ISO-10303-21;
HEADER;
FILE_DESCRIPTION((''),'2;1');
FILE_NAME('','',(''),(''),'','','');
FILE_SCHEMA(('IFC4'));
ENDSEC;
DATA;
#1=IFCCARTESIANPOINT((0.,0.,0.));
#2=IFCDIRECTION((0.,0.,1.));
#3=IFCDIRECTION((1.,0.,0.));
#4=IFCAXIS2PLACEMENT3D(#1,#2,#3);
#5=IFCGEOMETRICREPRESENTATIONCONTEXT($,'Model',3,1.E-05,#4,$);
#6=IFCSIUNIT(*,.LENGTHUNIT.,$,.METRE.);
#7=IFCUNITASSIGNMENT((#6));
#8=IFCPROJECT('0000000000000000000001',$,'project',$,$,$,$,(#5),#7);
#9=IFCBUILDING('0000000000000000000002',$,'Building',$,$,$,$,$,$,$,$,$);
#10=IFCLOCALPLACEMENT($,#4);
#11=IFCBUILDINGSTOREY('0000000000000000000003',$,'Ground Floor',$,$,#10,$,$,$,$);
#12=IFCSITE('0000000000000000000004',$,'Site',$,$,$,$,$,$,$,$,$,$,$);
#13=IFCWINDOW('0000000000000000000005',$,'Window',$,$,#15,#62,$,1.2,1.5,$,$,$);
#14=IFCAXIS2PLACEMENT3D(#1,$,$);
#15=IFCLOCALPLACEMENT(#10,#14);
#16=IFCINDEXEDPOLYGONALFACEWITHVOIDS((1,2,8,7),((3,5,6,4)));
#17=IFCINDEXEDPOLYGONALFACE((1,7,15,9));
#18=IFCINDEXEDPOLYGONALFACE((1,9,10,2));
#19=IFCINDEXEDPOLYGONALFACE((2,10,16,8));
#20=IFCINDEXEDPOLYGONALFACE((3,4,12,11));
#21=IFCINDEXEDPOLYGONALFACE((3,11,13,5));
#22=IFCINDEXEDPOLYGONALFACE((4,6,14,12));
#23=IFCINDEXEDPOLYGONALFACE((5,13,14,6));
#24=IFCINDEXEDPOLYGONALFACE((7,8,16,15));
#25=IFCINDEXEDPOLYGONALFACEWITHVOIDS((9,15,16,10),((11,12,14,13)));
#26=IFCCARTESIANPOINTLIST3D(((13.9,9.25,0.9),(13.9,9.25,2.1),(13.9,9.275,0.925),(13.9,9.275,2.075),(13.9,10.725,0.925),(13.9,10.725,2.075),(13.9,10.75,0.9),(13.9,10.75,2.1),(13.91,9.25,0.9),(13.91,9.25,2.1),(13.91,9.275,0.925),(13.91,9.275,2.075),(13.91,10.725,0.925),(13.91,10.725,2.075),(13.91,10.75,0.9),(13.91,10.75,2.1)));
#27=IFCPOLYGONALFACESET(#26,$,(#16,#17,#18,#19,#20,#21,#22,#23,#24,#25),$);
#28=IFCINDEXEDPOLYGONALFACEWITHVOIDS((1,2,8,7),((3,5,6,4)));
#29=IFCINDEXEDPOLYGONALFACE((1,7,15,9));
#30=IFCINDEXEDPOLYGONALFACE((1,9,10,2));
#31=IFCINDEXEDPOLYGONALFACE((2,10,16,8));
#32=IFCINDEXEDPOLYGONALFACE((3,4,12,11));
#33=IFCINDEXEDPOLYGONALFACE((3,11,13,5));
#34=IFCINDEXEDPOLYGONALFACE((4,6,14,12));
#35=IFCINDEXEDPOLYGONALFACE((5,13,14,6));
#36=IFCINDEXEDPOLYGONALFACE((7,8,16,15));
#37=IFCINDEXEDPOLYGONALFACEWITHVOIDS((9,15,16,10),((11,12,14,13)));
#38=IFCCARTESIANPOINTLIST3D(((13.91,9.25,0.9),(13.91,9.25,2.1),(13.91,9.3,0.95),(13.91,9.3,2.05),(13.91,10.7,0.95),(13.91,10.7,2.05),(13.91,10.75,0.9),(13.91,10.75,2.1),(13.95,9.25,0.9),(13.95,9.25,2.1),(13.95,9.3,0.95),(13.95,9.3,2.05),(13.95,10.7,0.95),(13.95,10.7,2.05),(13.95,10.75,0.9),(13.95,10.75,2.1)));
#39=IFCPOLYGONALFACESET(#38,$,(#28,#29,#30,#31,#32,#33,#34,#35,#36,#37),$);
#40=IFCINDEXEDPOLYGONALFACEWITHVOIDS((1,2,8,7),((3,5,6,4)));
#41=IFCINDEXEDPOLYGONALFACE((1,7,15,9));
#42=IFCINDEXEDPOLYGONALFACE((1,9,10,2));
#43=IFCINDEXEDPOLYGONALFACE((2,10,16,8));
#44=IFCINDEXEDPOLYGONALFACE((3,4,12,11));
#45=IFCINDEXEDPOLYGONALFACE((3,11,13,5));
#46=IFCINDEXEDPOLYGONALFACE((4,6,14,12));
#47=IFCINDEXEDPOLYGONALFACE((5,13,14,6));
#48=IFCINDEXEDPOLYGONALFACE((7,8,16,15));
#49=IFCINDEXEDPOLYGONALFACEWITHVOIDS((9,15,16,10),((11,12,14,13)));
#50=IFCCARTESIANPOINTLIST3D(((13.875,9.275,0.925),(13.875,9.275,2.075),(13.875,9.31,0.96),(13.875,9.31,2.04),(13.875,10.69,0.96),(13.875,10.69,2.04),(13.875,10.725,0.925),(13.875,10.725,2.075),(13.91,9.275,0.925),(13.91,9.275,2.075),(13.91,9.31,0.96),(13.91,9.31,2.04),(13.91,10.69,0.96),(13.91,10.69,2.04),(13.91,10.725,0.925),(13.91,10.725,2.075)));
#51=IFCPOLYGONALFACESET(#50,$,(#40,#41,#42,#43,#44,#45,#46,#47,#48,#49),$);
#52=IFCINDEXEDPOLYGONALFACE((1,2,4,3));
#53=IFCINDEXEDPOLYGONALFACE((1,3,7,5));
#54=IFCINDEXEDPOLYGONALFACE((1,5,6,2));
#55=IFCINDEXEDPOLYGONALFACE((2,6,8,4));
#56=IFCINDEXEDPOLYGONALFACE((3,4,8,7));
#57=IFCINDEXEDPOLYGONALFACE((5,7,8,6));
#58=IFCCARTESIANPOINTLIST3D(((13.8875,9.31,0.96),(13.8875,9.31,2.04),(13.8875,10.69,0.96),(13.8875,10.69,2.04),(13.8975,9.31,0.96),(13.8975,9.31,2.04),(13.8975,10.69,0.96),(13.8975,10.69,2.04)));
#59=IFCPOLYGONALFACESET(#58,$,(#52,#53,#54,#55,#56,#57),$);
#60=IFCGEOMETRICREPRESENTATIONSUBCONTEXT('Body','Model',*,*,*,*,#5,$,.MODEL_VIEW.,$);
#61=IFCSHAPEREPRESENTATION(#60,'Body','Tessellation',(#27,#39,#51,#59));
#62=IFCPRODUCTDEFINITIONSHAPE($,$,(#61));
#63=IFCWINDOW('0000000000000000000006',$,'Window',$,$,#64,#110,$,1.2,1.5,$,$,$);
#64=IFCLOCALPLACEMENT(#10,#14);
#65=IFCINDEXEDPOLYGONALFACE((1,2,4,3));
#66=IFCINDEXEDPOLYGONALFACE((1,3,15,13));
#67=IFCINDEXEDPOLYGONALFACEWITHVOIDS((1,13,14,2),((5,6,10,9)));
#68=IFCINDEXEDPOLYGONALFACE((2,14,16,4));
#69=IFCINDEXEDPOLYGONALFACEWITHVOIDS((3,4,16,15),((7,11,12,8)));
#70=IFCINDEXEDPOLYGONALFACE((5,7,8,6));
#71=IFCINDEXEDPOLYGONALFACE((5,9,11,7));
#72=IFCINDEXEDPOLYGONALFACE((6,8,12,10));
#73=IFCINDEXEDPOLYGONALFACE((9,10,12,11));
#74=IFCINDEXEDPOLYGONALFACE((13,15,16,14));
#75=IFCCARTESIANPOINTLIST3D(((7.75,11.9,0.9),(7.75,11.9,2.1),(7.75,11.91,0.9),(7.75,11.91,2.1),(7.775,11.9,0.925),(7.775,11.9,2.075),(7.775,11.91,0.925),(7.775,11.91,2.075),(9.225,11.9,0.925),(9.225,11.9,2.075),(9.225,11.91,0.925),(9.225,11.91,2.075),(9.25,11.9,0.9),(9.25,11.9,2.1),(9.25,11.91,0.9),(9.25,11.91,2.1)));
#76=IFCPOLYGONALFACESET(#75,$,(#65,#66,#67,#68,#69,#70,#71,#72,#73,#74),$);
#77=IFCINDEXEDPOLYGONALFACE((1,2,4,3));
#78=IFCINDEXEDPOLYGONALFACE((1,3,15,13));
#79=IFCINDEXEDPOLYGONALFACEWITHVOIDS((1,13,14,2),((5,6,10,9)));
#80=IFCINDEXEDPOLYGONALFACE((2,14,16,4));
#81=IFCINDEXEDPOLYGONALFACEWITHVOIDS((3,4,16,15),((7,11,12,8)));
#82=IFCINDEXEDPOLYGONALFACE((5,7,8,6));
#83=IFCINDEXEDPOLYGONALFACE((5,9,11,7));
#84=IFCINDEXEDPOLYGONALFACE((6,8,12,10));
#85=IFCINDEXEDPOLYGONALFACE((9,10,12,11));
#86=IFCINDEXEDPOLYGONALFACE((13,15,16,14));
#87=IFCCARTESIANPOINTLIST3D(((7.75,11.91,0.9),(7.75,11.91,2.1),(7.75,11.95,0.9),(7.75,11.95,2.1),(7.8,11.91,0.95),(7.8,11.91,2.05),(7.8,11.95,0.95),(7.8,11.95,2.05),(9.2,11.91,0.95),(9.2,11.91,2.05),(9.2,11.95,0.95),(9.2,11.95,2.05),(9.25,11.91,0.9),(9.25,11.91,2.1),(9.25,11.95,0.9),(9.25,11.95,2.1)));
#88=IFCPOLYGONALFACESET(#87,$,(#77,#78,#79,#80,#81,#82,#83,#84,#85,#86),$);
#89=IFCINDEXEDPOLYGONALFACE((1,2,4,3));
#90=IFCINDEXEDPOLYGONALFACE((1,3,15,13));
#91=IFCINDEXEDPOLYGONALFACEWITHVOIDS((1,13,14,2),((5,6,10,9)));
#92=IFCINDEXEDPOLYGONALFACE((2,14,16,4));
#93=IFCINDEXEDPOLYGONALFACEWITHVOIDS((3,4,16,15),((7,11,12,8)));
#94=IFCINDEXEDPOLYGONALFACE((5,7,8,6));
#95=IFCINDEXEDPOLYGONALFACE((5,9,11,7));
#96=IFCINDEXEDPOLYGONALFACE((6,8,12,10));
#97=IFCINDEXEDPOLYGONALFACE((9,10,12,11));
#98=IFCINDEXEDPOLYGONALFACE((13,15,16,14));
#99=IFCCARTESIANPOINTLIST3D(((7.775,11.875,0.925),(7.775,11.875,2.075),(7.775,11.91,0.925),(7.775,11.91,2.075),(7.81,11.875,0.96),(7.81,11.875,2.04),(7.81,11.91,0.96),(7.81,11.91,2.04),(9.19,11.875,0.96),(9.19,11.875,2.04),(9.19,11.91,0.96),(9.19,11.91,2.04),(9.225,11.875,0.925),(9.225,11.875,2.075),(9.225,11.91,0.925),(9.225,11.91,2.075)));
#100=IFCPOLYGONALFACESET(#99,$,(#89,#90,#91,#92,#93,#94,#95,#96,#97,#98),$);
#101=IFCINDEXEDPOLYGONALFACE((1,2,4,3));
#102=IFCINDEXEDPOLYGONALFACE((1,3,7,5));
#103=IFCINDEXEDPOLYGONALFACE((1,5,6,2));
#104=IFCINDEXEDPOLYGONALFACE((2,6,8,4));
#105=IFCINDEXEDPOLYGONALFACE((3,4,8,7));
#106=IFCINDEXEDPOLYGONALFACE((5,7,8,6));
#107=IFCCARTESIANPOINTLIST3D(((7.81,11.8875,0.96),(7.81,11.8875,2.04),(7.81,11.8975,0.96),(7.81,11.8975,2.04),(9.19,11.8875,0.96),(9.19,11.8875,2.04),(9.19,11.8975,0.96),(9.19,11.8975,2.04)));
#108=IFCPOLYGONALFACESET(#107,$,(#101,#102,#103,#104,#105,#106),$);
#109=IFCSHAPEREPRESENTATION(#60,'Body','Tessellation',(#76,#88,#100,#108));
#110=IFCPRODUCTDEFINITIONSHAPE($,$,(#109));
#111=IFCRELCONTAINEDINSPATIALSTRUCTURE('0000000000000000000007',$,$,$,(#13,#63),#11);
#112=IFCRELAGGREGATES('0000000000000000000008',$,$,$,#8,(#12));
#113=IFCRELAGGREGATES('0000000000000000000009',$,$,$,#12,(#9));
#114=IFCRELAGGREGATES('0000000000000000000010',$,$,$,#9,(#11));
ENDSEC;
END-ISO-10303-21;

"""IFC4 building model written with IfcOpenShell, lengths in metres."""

from ifc_helpers import new_model, si_unit, frame, origin_with_axes, place, context, subcontext, project, spatial, line, indexed_curve, outline, extrude, element, save


model = new_model("IFC4")

# Units and contexts
model_context = context("Model", 3, precision=1e-05, world=origin_with_axes())
body_context = subcontext(model_context, "Body", "Model", "MODEL_VIEW")
ifc_project = project(units=[si_unit("LENGTHUNIT", "METRE")], contexts=[model_context])

# Site, building, storey
site = spatial("IfcSite", under=ifc_project, Name="Site")
building = spatial("IfcBuilding", under=site, Name="Building")
storey_placement = place(None, origin_with_axes())
storey = spatial("IfcBuildingStorey", under=building, at=storey_placement, Name="Ground Floor")

# Windows
for number, where, z_axis, x_axis, name in (
    (1, (14.0, 9.25, 0.9), (0.0, 0.0, 1.0), (0.0, 1.0, 0.0), "Window"),
    (2, (9.25, 12.0, 0.9), (0.0, 0.0, 1.0), (-1.0, 0.0, 0.0), "Window"),
):
    element("IfcWindow", number, at=place(storey_placement, frame(where, z_axis=z_axis, x_axis=x_axis)), inside=storey, Name=name, OverallHeight=1.2, OverallWidth=1.5, context=body_context, shape_type="SweptSolid", body=[
        extrude(outline(indexed_curve([(0.0, 0.0), (1.5, 0.0), (1.5, 1.2), (0.0, 1.2)], segments=[line(1, 2, 3, 4, 1)]), holes=[indexed_curve([(0.025, 0.025), (1.475, 0.025), (1.475, 1.175), (0.025, 1.175)], segments=[line(1, 2, 3, 4, 1)])]), frame((0.0, 0.09, 0.0), z_axis=(0.0, -1.0, 0.0), x_axis=(1.0, 0.0, 0.0)), (0.0, 0.0, -1.0), 0.01),
        extrude(outline(indexed_curve([(0.0, 0.0), (1.5, 0.0), (1.5, 1.2), (0.0, 1.2)], segments=[line(1, 2, 3, 4, 1)]), holes=[indexed_curve([(0.05, 0.05), (1.45, 0.05), (1.45, 1.15), (0.05, 1.15)], segments=[line(1, 2, 3, 4, 1)])]), frame((0.0, 0.05, 0.0), z_axis=(0.0, -1.0, 0.0), x_axis=(1.0, 0.0, 0.0)), (0.0, 0.0, -1.0), 0.04),
        extrude(outline(indexed_curve([(0.0, 0.0), (1.45, 0.0), (1.45, 1.15), (0.0, 1.15)], segments=[line(1, 2, 3, 4, 1)]), holes=[indexed_curve([(0.035, 0.035), (1.415, 0.035), (1.415, 1.115), (0.035, 1.115)], segments=[line(1, 2, 3, 4, 1)])]), frame((0.025, 0.09, 0.025), z_axis=(0.0, -1.0, 0.0), x_axis=(1.0, 0.0, 0.0)), (0.0, 0.0, -1.0), 0.035),
        extrude(outline(indexed_curve([(0.035, 0.035), (1.415, 0.035), (1.415, 1.115), (0.035, 1.115)], segments=[line(1, 2, 3, 4, 1)])), frame((0.025, 0.1025, 0.025), z_axis=(0.0, -1.0, 0.0), x_axis=(1.0, 0.0, 0.0)), (0.0, 0.0, -1.0), 0.01),
    ])

save(model, "model.ifc")
